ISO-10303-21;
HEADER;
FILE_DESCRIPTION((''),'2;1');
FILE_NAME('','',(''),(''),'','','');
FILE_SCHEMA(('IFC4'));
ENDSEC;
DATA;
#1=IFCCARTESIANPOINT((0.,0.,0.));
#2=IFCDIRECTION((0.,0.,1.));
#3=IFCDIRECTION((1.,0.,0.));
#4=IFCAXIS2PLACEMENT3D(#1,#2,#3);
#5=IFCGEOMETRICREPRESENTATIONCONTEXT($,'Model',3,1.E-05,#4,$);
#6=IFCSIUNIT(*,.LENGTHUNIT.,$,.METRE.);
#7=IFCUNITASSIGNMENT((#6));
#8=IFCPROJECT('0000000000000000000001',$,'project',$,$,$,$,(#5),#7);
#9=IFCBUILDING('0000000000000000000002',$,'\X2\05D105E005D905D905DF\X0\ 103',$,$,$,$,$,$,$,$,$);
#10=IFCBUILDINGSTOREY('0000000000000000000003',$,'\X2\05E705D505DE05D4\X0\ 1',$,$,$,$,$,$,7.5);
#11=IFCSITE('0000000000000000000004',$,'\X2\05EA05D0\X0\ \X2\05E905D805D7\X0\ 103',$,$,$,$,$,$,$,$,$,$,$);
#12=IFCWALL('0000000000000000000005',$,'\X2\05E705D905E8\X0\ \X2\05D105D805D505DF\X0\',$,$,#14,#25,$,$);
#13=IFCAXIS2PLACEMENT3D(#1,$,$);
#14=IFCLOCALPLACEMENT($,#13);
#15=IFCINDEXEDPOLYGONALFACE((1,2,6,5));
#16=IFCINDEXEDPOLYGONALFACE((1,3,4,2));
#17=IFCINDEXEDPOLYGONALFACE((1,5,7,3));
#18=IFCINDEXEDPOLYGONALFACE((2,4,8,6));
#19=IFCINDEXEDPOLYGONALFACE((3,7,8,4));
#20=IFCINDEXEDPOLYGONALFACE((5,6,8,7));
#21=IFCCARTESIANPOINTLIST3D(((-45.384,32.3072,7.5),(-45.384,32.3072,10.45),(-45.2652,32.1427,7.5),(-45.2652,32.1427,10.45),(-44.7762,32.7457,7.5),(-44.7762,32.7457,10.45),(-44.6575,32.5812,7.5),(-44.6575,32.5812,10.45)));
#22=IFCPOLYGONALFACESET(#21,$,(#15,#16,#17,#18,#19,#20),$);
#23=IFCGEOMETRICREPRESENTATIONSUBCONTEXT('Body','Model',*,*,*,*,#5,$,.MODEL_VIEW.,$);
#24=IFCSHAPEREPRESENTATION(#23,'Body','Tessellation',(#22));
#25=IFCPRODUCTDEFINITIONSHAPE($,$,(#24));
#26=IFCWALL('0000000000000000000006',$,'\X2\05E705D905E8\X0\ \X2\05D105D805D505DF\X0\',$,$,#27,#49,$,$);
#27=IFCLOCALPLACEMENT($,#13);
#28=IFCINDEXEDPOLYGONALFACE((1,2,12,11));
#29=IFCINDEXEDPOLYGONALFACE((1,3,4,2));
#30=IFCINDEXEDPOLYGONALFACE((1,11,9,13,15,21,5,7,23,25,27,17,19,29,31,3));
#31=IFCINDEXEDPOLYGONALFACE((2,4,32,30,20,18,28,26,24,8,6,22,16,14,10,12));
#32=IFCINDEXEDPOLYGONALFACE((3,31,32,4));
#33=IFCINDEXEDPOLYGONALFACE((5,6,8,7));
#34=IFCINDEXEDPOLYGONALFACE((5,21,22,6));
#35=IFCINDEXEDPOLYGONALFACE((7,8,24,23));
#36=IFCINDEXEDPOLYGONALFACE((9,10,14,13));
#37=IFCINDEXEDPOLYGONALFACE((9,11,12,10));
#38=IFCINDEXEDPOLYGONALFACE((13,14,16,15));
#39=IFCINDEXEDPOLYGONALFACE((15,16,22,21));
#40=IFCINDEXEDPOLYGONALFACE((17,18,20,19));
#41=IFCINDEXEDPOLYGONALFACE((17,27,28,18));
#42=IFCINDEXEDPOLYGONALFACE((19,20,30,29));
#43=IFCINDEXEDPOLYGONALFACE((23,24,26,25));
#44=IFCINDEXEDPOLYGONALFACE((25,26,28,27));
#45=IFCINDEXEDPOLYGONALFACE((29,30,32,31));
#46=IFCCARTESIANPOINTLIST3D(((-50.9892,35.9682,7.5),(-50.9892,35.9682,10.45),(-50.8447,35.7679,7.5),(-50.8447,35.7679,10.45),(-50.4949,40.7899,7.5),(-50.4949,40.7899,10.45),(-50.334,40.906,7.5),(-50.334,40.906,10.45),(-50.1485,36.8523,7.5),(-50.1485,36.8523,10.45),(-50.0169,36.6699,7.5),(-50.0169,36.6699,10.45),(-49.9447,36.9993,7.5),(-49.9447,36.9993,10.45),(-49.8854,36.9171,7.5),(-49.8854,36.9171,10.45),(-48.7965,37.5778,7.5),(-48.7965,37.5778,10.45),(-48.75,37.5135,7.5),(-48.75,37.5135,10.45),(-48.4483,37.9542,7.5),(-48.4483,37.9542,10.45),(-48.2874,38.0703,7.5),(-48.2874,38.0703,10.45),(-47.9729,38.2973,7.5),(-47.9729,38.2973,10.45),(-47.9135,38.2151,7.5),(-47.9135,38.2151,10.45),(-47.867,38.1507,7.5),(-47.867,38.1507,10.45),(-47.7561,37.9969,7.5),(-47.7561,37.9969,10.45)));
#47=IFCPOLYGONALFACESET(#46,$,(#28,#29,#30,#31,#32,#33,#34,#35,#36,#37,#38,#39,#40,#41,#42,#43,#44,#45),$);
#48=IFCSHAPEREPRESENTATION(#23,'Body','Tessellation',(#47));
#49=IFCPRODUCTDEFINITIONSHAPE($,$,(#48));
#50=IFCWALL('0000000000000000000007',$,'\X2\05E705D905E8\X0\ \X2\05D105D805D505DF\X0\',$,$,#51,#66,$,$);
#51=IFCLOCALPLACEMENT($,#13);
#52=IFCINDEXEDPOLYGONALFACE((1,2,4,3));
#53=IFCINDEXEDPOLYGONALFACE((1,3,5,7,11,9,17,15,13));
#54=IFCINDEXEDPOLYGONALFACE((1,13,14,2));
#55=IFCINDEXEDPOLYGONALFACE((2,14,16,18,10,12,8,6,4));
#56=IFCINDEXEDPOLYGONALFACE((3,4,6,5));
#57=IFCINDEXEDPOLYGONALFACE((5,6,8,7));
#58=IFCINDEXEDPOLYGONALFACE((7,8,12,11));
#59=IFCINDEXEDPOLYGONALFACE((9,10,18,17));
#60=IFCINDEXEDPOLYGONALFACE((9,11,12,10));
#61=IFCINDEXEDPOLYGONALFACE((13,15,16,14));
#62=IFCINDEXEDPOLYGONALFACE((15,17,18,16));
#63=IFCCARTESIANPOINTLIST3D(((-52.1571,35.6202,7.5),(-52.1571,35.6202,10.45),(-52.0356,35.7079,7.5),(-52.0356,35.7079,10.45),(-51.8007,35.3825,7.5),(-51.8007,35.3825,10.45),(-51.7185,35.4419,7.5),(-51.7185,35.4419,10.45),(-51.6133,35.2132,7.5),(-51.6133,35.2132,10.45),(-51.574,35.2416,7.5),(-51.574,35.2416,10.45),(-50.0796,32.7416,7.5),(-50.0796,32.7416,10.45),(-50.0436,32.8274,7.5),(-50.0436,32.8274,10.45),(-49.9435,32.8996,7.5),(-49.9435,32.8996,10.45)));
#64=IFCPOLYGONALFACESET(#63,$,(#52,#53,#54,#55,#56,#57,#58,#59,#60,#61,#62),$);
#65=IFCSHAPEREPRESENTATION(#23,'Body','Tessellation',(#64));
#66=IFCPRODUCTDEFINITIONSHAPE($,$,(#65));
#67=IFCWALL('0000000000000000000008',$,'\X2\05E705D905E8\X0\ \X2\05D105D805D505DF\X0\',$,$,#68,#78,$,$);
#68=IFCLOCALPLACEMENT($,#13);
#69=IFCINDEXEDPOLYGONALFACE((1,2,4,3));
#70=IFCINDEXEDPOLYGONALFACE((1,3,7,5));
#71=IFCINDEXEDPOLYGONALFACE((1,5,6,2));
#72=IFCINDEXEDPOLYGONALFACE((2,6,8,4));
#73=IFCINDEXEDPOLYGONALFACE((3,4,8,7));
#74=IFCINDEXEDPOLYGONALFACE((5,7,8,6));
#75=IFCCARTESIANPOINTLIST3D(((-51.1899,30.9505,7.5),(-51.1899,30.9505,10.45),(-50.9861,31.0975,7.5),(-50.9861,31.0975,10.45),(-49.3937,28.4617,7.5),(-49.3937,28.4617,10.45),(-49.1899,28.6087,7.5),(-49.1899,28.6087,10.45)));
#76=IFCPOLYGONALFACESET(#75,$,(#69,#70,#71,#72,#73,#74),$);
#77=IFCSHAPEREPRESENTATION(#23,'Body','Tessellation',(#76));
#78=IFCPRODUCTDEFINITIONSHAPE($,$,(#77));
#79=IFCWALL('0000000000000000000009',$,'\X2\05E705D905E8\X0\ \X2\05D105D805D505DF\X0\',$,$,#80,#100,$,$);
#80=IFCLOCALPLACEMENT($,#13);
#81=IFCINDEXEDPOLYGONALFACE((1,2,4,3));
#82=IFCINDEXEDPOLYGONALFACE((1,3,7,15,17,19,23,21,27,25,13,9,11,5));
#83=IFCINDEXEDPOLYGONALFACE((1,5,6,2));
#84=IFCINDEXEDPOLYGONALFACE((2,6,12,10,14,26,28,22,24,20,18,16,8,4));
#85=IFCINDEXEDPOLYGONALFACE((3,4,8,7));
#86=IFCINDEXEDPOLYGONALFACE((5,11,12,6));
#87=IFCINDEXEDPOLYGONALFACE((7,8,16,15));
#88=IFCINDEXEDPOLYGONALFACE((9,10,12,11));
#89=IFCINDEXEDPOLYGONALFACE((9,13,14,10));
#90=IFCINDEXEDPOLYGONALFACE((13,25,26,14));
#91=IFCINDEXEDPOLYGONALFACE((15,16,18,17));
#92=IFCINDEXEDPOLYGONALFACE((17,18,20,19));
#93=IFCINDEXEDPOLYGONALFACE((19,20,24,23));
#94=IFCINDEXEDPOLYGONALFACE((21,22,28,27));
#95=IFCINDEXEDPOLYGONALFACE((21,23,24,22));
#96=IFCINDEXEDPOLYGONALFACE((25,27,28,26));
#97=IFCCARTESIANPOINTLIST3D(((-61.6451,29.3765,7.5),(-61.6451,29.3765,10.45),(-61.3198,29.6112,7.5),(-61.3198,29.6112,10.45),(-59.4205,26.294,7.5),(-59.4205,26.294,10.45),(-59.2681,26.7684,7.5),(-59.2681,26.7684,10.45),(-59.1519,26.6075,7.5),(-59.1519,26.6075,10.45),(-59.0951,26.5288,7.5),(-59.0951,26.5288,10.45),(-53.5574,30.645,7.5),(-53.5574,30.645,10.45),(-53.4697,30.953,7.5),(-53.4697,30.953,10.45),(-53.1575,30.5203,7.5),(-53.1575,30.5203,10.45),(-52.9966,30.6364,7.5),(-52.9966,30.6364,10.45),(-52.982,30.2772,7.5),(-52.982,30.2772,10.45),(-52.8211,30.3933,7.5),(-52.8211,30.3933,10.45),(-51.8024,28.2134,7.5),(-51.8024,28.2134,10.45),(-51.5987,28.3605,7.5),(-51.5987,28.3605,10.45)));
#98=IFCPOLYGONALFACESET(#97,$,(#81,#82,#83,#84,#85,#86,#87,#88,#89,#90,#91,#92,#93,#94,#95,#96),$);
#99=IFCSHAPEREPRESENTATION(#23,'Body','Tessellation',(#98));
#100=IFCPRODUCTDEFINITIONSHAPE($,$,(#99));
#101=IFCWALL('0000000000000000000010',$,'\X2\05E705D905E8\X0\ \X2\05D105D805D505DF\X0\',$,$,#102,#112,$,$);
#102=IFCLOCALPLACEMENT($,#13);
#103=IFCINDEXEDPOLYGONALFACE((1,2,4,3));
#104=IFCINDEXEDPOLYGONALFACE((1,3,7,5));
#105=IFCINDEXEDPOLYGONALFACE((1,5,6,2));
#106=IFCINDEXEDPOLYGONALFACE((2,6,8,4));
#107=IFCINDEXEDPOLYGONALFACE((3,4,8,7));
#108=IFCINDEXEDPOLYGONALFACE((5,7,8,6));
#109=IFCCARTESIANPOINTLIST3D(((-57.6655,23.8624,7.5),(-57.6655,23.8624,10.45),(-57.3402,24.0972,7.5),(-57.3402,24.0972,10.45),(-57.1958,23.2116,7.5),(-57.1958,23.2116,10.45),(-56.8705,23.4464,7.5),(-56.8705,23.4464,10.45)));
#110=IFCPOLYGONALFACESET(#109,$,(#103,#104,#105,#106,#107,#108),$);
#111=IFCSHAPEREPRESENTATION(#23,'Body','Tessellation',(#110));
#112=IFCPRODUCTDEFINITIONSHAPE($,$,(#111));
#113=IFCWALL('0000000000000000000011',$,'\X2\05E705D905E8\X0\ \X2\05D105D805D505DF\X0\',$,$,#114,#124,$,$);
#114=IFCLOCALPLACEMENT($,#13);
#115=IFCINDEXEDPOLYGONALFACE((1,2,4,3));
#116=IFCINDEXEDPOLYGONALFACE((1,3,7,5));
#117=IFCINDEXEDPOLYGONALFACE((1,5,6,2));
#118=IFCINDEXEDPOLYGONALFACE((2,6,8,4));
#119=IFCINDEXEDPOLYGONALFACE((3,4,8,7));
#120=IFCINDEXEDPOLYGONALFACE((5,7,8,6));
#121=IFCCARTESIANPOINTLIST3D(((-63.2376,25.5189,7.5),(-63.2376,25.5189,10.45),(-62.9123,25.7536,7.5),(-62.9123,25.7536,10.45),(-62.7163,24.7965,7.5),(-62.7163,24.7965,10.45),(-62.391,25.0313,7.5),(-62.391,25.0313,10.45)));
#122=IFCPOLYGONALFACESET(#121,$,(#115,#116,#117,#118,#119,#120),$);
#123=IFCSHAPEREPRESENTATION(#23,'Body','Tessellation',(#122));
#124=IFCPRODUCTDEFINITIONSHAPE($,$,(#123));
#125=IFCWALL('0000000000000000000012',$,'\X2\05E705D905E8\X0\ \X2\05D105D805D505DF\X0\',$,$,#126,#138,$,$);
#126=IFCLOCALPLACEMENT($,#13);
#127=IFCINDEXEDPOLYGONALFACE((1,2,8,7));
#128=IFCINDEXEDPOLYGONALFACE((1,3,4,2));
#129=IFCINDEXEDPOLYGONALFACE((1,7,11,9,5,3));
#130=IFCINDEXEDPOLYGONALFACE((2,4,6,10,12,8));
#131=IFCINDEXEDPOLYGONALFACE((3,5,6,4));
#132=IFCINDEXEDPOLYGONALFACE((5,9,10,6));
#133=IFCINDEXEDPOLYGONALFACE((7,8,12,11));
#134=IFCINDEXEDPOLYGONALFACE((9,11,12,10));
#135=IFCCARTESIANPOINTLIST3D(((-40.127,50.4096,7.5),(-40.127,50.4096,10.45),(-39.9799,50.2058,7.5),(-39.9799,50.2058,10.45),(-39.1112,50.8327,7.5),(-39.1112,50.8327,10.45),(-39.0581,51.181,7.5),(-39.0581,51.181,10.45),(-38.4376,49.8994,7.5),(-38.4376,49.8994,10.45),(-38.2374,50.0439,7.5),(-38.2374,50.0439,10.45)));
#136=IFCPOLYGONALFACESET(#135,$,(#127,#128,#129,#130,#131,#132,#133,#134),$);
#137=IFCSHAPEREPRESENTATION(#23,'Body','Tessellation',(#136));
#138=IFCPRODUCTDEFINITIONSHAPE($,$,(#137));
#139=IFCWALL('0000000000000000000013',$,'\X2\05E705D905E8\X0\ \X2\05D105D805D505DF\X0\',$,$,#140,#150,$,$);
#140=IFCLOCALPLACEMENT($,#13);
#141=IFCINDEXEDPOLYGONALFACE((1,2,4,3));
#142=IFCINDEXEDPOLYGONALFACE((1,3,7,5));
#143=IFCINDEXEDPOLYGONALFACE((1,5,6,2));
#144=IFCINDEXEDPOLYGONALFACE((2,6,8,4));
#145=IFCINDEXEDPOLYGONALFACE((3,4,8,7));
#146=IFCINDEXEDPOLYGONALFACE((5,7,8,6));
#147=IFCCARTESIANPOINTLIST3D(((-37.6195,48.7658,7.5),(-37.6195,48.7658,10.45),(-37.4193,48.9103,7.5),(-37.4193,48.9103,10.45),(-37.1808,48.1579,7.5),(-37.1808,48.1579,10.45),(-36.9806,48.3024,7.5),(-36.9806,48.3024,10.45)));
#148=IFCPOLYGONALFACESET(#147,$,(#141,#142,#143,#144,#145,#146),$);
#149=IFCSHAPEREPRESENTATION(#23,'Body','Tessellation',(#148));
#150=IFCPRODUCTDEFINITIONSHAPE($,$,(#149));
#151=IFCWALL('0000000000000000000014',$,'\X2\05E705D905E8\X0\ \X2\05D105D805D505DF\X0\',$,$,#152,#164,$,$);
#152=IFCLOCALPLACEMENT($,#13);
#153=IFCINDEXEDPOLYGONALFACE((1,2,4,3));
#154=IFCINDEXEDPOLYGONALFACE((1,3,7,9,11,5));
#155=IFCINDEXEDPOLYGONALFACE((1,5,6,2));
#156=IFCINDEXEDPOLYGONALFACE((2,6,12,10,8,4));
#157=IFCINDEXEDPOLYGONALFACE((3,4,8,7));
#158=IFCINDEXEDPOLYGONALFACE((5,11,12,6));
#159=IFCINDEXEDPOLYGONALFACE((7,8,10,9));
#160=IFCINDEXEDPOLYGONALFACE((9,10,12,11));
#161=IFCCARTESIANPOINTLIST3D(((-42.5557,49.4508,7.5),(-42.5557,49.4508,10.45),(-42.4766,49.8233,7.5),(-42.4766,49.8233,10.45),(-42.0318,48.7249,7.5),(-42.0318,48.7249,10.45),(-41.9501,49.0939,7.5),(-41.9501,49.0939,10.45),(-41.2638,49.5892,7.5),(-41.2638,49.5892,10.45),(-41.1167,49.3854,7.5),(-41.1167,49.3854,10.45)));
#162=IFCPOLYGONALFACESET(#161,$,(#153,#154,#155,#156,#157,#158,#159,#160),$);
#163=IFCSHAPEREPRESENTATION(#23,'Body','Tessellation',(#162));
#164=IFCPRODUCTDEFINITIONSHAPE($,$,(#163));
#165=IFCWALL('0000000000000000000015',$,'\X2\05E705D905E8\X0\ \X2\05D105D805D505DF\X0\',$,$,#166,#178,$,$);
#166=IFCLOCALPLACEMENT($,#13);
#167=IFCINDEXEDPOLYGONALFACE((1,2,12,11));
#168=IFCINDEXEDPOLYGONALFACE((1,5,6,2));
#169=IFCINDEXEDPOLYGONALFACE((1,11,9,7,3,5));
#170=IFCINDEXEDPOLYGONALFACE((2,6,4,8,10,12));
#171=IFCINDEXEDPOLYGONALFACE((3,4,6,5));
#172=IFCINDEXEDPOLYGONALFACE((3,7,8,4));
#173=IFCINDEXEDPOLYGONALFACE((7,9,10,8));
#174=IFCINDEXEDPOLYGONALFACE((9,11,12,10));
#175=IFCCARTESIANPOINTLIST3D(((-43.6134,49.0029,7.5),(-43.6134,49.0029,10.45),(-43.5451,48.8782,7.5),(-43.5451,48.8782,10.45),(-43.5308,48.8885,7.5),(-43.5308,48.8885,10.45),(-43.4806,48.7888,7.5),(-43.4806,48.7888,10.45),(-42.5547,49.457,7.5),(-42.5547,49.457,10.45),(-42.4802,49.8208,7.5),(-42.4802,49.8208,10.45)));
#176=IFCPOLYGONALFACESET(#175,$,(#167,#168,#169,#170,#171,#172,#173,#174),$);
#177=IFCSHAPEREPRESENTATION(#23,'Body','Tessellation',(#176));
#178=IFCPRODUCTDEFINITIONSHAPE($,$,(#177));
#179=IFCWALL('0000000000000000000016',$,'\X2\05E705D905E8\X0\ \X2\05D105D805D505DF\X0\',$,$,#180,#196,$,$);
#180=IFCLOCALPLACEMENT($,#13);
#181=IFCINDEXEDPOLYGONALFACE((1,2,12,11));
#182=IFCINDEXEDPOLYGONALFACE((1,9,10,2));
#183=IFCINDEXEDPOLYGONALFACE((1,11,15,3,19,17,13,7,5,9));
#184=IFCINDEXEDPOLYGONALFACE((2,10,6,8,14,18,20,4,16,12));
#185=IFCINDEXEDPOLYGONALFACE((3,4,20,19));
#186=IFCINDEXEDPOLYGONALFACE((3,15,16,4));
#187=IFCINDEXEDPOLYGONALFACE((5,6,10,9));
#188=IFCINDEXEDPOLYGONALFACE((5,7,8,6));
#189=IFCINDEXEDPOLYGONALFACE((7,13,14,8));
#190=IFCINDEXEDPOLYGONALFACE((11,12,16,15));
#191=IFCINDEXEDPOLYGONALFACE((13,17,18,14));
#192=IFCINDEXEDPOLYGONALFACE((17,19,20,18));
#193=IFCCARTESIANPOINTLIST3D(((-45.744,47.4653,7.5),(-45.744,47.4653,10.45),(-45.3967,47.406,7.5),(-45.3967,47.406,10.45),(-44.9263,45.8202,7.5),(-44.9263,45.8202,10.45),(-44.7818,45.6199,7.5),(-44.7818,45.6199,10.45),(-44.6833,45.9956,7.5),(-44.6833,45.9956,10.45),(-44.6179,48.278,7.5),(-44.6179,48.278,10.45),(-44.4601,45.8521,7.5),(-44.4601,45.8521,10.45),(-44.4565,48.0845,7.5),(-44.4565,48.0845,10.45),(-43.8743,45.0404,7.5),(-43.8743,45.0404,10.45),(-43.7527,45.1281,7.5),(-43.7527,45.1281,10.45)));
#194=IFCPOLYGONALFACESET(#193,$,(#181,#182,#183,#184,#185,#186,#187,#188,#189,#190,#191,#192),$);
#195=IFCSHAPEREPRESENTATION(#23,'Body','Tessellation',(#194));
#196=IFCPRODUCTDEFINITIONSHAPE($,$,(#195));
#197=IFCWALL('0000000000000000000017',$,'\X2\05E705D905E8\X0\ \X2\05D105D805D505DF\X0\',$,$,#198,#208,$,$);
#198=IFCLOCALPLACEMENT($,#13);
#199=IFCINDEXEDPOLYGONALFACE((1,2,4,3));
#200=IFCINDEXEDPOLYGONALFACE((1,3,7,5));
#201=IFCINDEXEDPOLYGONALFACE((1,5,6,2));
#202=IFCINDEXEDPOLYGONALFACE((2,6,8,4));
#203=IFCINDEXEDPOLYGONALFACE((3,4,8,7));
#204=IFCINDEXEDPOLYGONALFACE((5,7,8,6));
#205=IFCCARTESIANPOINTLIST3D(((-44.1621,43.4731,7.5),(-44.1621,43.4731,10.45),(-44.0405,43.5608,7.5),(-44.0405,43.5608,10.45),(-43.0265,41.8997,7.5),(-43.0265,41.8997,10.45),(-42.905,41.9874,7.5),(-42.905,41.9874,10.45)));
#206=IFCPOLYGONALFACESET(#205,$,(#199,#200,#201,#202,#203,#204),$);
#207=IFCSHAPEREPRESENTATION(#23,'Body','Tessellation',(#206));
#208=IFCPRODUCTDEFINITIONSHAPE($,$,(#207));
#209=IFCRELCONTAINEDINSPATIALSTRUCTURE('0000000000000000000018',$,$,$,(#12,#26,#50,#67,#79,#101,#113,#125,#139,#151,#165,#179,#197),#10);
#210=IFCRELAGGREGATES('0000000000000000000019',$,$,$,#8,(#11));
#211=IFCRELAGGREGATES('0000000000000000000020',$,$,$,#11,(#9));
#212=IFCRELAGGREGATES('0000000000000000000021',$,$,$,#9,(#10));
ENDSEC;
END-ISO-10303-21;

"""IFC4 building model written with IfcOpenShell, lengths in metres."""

from ifc_helpers import new_model, si_unit, frame, origin_with_axes, context, subcontext, project, spatial, polyline, outline, extrude, element, save


model = new_model("IFC4")

# Units and contexts
model_context = context("Model", 3, precision=1e-05, world=origin_with_axes())
body_context = subcontext(model_context, "Body", "Model", "MODEL_VIEW")
ifc_project = project(units=[si_unit("LENGTHUNIT", "METRE")], contexts=[model_context])

# Site, building, storey
site = spatial("IfcSite", under=ifc_project, Name="תא שטח 103")
building = spatial("IfcBuilding", under=site, Name="בניין 103")
storey = spatial("IfcBuildingStorey", under=building, Name="קומה 1", Elevation=7.5)

# Walls
element("IfcWall", 1, inside=storey, Name="קיר בטון", context=body_context, shape_type="SweptSolid", body=[
    extrude(outline(polyline([(-45.384, 32.3072), (-44.7762, 32.7457), (-44.6575, 32.5812), (-45.2652, 32.1427), (-45.384, 32.3072)])), frame((0.0, 0.0, 7.5)), (0.0, 0.0, 1.0), 2.95),
])
element("IfcWall", 2, inside=storey, Name="קיר בטון", context=body_context, shape_type="SweptSolid", body=[
    extrude(outline(polyline([(-47.7561, 37.9969), (-50.8447, 35.7679), (-50.9892, 35.9682), (-50.0169, 36.6699), (-50.1485, 36.8523), (-49.9447, 36.9993), (-49.8854, 36.9171), (-48.4483, 37.9542), (-50.4949, 40.7899), (-50.334, 40.906), (-48.2874, 38.0703), (-47.9729, 38.2973), (-47.9135, 38.2151), (-48.7965, 37.5778), (-48.75, 37.5135), (-47.867, 38.1507), (-47.7561, 37.9969)])), frame((0.0, 0.0, 7.5)), (0.0, 0.0, 1.0), 2.95),
])
element("IfcWall", 3, inside=storey, Name="קיר בטון", context=body_context, shape_type="SweptSolid", body=[
    extrude(outline(polyline([(-50.0796, 32.7416), (-52.1571, 35.6202), (-52.0356, 35.7079), (-51.8007, 35.3825), (-51.7185, 35.4419), (-51.574, 35.2416), (-51.6133, 35.2132), (-49.9435, 32.8996), (-50.0436, 32.8274), (-50.0796, 32.7416)])), frame((0.0, 0.0, 7.5)), (0.0, 0.0, 1.0), 2.95),
])
element("IfcWall", 4, inside=storey, Name="קיר בטון", context=body_context, shape_type="SweptSolid", body=[
    extrude(outline(polyline([(-49.3937, 28.4617), (-51.1899, 30.9505), (-50.9861, 31.0975), (-49.1899, 28.6087), (-49.3937, 28.4617)])), frame((0.0, 0.0, 7.5)), (0.0, 0.0, 1.0), 2.95),
])
element("IfcWall", 5, inside=storey, Name="קיר בטון", context=body_context, shape_type="SweptSolid", body=[
    extrude(outline(polyline([(-52.982, 30.2772), (-51.5987, 28.3605), (-51.8024, 28.2134), (-53.5574, 30.645), (-59.1519, 26.6075), (-59.0951, 26.5288), (-59.4205, 26.294), (-61.6451, 29.3765), (-61.3198, 29.6112), (-59.2681, 26.7684), (-53.4697, 30.953), (-53.1575, 30.5203), (-52.9966, 30.6364), (-52.8211, 30.3933), (-52.982, 30.2772)])), frame((0.0, 0.0, 7.5)), (0.0, 0.0, 1.0), 2.95),
])
element("IfcWall", 6, inside=storey, Name="קיר בטון", context=body_context, shape_type="SweptSolid", body=[
    extrude(outline(polyline([(-56.8705, 23.4464), (-57.1958, 23.2116), (-57.6655, 23.8624), (-57.3402, 24.0972), (-56.8705, 23.4464)])), frame((0.0, 0.0, 7.5)), (0.0, 0.0, 1.0), 2.95),
])
element("IfcWall", 7, inside=storey, Name="קיר בטון", context=body_context, shape_type="SweptSolid", body=[
    extrude(outline(polyline([(-62.391, 25.0313), (-62.7163, 24.7965), (-63.2376, 25.5189), (-62.9123, 25.7536), (-62.391, 25.0313)])), frame((0.0, 0.0, 7.5)), (0.0, 0.0, 1.0), 2.95),
])
element("IfcWall", 8, inside=storey, Name="קיר בטון", context=body_context, shape_type="SweptSolid", body=[
    extrude(outline(polyline([(-40.127, 50.4096), (-39.0581, 51.181), (-38.2374, 50.0439), (-38.4376, 49.8994), (-39.1112, 50.8327), (-39.9799, 50.2058), (-40.127, 50.4096)])), frame((0.0, 0.0, 7.5)), (0.0, 0.0, 1.0), 2.95),
])
element("IfcWall", 9, inside=storey, Name="קיר בטון", context=body_context, shape_type="SweptSolid", body=[
    extrude(outline(polyline([(-36.9806, 48.3024), (-37.1808, 48.1579), (-37.6195, 48.7658), (-37.4193, 48.9103), (-36.9806, 48.3024)])), frame((0.0, 0.0, 7.5)), (0.0, 0.0, 1.0), 2.95),
])
element("IfcWall", 10, inside=storey, Name="קיר בטון", context=body_context, shape_type="SweptSolid", body=[
    extrude(outline(polyline([(-42.4766, 49.8233), (-41.9501, 49.0939), (-41.2638, 49.5892), (-41.1167, 49.3854), (-42.0318, 48.7249), (-42.5557, 49.4508), (-42.4766, 49.8233)])), frame((0.0, 0.0, 7.5)), (0.0, 0.0, 1.0), 2.95),
])
element("IfcWall", 11, inside=storey, Name="קיר בטון", context=body_context, shape_type="SweptSolid", body=[
    extrude(outline(polyline([(-43.5451, 48.8782), (-43.5308, 48.8885), (-43.6134, 49.0029), (-42.4802, 49.8208), (-42.5547, 49.457), (-43.4806, 48.7888), (-43.5451, 48.8782)])), frame((0.0, 0.0, 7.5)), (0.0, 0.0, 1.0), 2.95),
])
element("IfcWall", 12, inside=storey, Name="קיר בטון", context=body_context, shape_type="SweptSolid", body=[
    extrude(outline(polyline([(-43.7527, 45.1281), (-43.8743, 45.0404), (-44.4601, 45.8521), (-44.7818, 45.6199), (-44.9263, 45.8202), (-44.6833, 45.9956), (-45.744, 47.4653), (-44.6179, 48.278), (-44.4565, 48.0845), (-45.3967, 47.406), (-43.7527, 45.1281)])), frame((0.0, 0.0, 7.5)), (0.0, 0.0, 1.0), 2.95),
])
element("IfcWall", 13, inside=storey, Name="קיר בטון", context=body_context, shape_type="SweptSolid", body=[
    extrude(outline(polyline([(-44.1621, 43.4731), (-44.0405, 43.5608), (-42.905, 41.9874), (-43.0265, 41.8997), (-44.1621, 43.4731)])), frame((0.0, 0.0, 7.5)), (0.0, 0.0, 1.0), 2.95),
])

save(model, "model.ifc")
